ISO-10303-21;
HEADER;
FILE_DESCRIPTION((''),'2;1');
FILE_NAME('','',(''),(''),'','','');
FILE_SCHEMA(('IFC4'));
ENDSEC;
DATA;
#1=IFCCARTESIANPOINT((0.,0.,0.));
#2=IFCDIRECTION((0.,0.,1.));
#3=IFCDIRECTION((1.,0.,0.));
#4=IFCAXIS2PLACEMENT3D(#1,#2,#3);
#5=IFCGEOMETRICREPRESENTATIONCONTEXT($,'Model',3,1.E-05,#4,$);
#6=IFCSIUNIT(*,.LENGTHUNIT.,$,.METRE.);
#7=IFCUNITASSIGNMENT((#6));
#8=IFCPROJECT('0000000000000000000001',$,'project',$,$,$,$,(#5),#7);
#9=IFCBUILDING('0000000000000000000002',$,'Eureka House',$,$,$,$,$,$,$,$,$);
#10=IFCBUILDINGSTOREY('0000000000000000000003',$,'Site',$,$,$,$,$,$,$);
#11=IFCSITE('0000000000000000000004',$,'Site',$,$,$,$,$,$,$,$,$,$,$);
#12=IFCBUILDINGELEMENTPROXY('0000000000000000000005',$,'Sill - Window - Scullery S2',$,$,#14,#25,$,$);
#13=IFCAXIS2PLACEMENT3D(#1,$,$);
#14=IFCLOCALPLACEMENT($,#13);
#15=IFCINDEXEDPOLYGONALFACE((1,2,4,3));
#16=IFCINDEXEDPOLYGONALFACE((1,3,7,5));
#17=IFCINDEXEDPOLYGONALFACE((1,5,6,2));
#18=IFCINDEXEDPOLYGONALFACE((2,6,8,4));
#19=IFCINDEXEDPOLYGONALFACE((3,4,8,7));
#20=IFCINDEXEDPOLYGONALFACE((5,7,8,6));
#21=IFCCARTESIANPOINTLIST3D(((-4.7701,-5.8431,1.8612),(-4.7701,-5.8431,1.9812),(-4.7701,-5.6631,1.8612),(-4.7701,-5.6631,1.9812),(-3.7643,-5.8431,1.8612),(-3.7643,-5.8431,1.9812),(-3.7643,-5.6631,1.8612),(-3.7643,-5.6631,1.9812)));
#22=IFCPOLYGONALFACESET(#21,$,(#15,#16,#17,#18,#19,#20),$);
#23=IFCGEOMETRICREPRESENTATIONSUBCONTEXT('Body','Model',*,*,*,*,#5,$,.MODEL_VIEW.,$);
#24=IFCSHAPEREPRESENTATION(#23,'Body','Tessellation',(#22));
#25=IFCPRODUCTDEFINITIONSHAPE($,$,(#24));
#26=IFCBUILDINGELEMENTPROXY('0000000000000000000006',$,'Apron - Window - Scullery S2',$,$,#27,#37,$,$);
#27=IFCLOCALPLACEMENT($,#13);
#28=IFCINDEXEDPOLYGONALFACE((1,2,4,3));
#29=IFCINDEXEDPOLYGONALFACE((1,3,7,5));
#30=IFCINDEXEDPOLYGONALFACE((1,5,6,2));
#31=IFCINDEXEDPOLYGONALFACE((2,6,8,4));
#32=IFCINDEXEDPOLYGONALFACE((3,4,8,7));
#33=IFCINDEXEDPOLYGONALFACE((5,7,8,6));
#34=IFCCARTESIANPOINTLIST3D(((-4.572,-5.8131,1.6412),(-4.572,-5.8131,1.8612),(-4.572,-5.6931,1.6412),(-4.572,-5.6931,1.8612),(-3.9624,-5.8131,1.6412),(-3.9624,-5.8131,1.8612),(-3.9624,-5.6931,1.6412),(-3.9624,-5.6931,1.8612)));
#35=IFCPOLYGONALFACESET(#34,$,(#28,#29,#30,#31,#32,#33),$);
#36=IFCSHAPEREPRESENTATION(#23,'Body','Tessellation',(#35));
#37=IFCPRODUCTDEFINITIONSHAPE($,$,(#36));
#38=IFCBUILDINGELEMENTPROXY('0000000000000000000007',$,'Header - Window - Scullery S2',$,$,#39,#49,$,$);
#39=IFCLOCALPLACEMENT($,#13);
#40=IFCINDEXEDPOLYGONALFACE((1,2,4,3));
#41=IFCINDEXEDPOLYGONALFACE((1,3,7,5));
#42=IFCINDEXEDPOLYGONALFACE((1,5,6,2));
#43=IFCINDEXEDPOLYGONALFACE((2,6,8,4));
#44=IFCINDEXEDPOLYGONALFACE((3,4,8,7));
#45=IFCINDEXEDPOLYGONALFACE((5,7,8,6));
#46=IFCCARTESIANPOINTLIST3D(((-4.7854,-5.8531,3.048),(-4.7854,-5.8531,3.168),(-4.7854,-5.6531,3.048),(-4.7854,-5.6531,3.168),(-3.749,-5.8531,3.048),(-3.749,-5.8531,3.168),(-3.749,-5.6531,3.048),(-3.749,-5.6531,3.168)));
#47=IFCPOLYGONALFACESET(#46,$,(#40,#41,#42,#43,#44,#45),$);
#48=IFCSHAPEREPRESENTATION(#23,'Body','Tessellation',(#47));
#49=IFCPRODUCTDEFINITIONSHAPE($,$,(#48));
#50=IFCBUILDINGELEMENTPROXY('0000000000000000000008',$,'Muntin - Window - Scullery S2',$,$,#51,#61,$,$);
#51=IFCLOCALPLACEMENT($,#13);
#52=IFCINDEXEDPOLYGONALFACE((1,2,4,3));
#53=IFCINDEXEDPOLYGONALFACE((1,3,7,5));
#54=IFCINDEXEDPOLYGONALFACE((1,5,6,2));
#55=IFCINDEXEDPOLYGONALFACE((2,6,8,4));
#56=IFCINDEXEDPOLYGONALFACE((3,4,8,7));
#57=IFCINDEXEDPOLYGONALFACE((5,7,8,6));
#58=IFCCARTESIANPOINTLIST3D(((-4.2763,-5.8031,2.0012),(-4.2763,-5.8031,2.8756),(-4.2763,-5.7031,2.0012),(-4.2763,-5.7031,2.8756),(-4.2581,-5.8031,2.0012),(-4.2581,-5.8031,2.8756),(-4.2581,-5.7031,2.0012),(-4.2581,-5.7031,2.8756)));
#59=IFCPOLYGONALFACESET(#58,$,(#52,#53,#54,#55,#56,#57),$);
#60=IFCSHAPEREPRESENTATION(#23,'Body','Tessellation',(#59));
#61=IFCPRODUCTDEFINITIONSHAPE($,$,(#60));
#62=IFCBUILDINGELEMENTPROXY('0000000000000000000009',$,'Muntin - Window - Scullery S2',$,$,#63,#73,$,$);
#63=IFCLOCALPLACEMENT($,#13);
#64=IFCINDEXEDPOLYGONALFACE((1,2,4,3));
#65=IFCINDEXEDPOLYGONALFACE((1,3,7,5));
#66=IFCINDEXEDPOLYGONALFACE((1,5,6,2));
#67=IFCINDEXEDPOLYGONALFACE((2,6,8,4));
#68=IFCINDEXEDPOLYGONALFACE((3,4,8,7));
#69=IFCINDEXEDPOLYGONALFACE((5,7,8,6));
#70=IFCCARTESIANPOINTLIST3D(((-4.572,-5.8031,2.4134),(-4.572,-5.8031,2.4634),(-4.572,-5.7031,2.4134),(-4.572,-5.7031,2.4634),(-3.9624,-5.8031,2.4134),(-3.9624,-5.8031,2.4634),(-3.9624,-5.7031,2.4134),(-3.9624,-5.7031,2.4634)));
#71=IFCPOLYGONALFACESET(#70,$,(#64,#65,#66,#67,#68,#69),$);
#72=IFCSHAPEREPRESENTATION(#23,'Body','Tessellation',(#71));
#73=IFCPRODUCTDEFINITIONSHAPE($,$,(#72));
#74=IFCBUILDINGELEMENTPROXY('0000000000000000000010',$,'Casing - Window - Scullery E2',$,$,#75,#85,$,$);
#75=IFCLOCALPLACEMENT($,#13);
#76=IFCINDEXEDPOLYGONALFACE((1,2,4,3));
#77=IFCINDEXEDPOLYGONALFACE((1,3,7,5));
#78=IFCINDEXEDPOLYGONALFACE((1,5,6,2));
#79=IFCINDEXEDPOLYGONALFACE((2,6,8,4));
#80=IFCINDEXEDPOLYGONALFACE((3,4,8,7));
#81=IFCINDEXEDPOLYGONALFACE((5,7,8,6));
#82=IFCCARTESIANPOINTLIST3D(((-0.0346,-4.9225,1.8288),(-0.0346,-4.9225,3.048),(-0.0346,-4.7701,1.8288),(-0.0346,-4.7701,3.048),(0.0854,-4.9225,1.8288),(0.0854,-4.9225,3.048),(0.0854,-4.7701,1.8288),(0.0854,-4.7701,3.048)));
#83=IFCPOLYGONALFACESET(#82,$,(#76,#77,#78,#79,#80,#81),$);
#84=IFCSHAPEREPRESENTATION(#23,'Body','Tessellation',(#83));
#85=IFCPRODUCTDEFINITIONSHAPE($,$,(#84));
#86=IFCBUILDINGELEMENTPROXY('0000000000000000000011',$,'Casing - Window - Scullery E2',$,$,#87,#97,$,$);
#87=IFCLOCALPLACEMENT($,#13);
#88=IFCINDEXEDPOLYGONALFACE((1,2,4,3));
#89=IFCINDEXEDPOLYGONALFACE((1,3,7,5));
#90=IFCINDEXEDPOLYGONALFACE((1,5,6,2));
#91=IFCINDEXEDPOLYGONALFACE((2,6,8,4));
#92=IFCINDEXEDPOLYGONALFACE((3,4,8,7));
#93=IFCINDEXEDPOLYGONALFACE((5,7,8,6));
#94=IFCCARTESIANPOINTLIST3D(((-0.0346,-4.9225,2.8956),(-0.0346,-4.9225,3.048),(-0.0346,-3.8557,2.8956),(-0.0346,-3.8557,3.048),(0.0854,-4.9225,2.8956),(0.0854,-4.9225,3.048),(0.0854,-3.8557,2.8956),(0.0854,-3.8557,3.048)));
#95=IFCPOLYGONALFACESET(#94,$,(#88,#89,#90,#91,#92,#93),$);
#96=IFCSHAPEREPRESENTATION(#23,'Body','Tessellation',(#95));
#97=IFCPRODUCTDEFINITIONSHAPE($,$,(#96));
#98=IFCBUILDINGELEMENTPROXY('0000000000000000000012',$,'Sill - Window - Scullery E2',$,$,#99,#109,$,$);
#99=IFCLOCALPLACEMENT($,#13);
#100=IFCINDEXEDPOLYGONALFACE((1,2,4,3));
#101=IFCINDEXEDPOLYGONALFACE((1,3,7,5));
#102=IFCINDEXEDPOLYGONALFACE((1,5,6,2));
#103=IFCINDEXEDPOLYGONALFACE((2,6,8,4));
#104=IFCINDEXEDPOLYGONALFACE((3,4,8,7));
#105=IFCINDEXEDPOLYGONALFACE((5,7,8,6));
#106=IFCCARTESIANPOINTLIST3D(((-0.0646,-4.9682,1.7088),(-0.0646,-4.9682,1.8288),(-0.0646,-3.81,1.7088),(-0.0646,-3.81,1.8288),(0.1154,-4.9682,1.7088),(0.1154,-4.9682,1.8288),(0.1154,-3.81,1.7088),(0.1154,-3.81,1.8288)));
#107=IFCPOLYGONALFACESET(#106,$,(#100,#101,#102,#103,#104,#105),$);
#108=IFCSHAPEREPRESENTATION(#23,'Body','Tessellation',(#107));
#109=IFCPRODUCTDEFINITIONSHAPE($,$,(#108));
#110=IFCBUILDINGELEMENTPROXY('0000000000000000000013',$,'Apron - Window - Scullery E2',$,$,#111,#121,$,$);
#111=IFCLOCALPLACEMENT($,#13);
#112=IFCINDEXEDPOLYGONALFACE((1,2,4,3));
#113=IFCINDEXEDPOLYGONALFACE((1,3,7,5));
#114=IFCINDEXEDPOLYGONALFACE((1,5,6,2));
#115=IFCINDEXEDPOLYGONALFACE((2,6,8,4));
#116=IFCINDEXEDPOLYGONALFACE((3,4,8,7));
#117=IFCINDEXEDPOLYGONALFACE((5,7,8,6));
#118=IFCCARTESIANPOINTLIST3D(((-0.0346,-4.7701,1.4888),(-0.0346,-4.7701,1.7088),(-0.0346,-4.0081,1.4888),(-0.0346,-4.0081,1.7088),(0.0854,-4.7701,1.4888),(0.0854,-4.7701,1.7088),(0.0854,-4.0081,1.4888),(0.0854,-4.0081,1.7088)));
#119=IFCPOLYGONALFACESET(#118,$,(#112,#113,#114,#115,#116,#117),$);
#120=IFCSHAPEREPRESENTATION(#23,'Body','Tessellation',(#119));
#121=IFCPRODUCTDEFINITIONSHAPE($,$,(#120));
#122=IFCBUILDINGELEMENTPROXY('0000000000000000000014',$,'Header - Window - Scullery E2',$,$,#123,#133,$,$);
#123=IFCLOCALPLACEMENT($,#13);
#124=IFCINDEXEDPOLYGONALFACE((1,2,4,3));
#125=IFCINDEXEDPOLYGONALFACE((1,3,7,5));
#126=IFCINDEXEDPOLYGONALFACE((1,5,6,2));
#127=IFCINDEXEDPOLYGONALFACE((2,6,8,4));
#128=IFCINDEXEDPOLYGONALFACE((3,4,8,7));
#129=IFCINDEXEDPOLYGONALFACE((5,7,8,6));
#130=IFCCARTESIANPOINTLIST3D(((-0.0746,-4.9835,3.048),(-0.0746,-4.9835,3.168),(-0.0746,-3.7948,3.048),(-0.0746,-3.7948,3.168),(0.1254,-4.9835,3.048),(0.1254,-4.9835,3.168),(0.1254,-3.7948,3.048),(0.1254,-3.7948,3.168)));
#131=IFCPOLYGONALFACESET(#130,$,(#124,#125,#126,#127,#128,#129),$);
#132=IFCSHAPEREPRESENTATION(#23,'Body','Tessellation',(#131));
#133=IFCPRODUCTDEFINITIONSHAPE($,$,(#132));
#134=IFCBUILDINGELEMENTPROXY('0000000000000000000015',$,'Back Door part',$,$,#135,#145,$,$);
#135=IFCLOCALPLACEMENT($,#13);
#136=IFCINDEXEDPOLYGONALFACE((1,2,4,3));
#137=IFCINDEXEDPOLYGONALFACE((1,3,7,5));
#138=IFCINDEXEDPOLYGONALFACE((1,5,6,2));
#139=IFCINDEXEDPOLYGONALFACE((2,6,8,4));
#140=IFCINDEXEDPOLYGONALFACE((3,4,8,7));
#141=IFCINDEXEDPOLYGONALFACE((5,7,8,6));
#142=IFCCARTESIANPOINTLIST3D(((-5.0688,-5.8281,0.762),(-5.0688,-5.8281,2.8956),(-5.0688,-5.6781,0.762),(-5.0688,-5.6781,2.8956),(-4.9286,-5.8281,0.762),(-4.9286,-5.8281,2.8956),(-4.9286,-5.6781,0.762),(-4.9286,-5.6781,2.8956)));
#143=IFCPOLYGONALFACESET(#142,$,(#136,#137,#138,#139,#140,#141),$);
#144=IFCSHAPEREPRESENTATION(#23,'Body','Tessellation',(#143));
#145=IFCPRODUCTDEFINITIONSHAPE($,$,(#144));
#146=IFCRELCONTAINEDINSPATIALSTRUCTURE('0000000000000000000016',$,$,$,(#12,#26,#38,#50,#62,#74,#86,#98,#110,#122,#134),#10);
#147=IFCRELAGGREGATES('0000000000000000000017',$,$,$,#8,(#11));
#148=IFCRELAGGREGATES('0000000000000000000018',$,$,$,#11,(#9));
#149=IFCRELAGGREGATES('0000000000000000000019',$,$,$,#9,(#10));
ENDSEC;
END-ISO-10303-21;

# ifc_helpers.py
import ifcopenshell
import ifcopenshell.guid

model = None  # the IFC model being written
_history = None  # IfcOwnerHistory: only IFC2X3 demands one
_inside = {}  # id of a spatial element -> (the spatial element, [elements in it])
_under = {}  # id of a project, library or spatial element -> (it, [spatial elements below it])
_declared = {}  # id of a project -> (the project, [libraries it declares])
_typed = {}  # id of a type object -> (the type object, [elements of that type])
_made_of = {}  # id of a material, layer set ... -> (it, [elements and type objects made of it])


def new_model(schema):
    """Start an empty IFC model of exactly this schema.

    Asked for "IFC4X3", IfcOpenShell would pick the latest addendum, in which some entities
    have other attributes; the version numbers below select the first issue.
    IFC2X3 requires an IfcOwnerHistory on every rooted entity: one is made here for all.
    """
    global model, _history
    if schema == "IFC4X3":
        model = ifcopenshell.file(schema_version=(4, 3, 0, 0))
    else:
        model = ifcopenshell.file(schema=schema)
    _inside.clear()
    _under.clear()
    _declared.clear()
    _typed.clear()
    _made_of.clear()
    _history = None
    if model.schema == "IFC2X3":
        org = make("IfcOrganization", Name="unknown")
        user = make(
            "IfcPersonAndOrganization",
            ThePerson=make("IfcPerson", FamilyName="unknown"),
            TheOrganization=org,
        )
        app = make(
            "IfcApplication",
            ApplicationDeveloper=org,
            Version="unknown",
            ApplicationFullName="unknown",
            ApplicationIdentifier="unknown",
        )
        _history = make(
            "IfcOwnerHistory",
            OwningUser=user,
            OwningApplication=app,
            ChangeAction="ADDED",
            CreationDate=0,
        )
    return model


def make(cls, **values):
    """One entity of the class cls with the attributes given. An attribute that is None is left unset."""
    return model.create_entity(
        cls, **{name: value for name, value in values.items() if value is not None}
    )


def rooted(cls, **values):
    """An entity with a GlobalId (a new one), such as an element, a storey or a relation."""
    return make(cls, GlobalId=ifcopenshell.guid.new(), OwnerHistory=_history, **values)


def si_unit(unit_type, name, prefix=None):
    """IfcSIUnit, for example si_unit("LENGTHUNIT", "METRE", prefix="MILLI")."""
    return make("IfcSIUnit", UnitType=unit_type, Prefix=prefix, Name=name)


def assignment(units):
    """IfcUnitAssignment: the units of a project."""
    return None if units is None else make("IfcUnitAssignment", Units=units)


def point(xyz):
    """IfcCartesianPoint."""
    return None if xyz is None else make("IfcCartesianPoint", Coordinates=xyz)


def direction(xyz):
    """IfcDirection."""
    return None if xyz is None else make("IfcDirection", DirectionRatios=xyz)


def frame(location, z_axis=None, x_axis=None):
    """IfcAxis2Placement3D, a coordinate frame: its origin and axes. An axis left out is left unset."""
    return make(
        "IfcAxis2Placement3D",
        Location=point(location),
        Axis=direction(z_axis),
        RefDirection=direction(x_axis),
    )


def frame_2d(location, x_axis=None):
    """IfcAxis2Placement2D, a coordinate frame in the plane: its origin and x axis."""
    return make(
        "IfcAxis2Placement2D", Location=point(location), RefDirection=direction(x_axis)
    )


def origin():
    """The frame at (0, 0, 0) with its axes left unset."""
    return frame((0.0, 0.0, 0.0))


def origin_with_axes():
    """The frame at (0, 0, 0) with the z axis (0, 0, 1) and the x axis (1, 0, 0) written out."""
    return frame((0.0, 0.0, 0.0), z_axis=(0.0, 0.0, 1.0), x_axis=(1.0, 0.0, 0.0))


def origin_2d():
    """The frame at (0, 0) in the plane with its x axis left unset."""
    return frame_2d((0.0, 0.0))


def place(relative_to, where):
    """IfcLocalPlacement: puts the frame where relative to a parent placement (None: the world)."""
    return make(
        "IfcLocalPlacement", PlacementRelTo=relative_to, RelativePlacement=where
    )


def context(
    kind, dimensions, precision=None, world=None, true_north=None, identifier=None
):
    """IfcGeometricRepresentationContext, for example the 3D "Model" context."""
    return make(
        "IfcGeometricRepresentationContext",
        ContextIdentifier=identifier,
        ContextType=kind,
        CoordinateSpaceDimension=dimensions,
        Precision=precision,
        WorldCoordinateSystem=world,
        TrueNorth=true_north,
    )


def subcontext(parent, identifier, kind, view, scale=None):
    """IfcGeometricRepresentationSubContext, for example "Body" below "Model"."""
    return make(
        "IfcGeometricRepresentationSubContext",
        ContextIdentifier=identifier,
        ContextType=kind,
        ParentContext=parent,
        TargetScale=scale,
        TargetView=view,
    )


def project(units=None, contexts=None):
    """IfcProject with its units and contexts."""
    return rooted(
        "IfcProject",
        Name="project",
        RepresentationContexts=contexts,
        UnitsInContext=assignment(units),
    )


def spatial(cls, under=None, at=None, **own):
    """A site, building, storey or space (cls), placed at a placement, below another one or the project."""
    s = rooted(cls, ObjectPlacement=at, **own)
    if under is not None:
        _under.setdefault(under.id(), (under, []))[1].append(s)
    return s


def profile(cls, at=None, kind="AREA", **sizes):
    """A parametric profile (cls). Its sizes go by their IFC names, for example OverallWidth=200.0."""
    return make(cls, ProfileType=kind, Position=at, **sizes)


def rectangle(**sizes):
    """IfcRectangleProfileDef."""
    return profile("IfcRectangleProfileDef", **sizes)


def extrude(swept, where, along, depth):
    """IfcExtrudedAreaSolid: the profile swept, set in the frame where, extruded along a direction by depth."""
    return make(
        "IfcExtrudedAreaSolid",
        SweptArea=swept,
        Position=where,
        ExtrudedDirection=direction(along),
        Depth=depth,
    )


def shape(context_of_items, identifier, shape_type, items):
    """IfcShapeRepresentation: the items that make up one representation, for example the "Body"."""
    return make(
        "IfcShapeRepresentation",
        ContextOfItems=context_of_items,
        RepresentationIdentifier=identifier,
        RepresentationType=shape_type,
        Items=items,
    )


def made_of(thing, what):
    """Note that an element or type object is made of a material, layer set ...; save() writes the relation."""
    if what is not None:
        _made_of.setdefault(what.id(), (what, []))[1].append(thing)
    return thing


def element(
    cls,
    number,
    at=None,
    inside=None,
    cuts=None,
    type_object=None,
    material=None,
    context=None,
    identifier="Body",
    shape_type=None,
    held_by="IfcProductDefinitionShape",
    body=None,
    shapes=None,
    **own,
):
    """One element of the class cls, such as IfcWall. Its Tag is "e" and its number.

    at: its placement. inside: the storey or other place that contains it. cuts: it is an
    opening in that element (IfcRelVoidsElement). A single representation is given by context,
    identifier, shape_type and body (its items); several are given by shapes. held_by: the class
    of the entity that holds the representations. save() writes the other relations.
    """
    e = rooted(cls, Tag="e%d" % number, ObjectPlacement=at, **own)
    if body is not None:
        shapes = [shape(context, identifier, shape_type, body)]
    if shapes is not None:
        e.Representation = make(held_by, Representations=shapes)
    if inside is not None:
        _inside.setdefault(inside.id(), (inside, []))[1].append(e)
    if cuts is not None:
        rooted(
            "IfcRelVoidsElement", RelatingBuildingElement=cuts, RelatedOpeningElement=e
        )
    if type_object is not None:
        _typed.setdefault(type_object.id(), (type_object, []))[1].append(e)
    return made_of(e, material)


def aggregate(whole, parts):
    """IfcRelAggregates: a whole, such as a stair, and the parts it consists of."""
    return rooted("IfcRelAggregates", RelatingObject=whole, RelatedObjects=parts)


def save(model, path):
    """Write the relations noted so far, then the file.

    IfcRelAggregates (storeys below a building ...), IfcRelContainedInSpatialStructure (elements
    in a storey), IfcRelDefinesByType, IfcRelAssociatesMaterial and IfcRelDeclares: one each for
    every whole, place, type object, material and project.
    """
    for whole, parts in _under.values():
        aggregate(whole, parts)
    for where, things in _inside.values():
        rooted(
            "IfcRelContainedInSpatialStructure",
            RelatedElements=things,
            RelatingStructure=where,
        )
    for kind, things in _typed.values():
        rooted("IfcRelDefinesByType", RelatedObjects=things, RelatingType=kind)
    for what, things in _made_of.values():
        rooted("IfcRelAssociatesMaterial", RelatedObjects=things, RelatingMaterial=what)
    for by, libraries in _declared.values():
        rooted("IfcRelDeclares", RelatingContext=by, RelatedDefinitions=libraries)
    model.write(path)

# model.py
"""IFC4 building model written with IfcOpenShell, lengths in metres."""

from ifc_helpers import new_model, si_unit, frame, origin, origin_with_axes, origin_2d, place, context, subcontext, project, spatial, rectangle, extrude, element, save


model = new_model("IFC4")

# Units and contexts
model_context = context("Model", 3, precision=1e-05, world=origin_with_axes())
body_context = subcontext(model_context, "Body", "Model", "MODEL_VIEW")
ifc_project = project(units=[si_unit("LENGTHUNIT", "METRE")], contexts=[model_context])

# Site, building, storey
site = spatial("IfcSite", under=ifc_project, Name="Site")
building = spatial("IfcBuilding", under=site, Name="Eureka House")
storey = spatial("IfcBuildingStorey", under=building, Name="Site")

# Building element proxies
proxy_1_placement = place(None, frame((-4.2672, -5.7531, 1.8612), z_axis=(0.0, 0.0, 1.0), x_axis=(1.0, 0.0, 0.0)))
element("IfcBuildingElementProxy", 1, at=proxy_1_placement, inside=storey, Name="Sill - Window - Scullery S2", context=body_context, shape_type="SweptSolid", body=[
    extrude(rectangle(XDim=1.0058, YDim=0.18, at=origin_2d()), origin(), (0.0, 0.0, 1.0), 0.12),
])
proxy_2_placement = place(None, frame((-4.2672, -5.7531, 1.6412), z_axis=(0.0, 0.0, 1.0), x_axis=(1.0, 0.0, 0.0)))
element("IfcBuildingElementProxy", 2, at=proxy_2_placement, inside=storey, Name="Apron - Window - Scullery S2", context=body_context, shape_type="SweptSolid", body=[
    extrude(rectangle(XDim=0.6096, YDim=0.12, at=origin_2d()), origin(), (0.0, 0.0, 1.0), 0.22),
])
proxy_3_placement = place(None, frame((-4.2672, -5.7531, 3.048), z_axis=(0.0, 0.0, 1.0), x_axis=(1.0, 0.0, 0.0)))
element("IfcBuildingElementProxy", 3, at=proxy_3_placement, inside=storey, Name="Header - Window - Scullery S2", context=body_context, shape_type="SweptSolid", body=[
    extrude(rectangle(XDim=1.0363, YDim=0.2, at=origin_2d()), origin(), (0.0, 0.0, 1.0), 0.12),
])
proxy_4_placement = place(None, frame((-4.2672, -5.7531, 2.0012), z_axis=(0.0, 0.0, 1.0), x_axis=(1.0, 0.0, 0.0)))
element("IfcBuildingElementProxy", 4, at=proxy_4_placement, inside=storey, Name="Muntin - Window - Scullery S2", context=body_context, shape_type="SweptSolid", body=[
    extrude(rectangle(XDim=0.0183, YDim=0.1, at=origin_2d()), origin(), (0.0, 0.0, 1.0), 0.8744),
])
proxy_5_placement = place(None, frame((-4.2672, -5.7531, 2.4134), z_axis=(0.0, 0.0, 1.0), x_axis=(1.0, 0.0, 0.0)))
element("IfcBuildingElementProxy", 5, at=proxy_5_placement, inside=storey, Name="Muntin - Window - Scullery S2", context=body_context, shape_type="SweptSolid", body=[
    extrude(rectangle(XDim=0.6096, YDim=0.1, at=origin_2d()), origin(), (0.0, 0.0, 1.0), 0.05),
])
proxy_6_placement = place(None, frame((0.0254, -4.8463, 1.8288), z_axis=(0.0, 0.0, 1.0), x_axis=(1.0, 0.0, 0.0)))
element("IfcBuildingElementProxy", 6, at=proxy_6_placement, inside=storey, Name="Casing - Window - Scullery E2", context=body_context, shape_type="SweptSolid", body=[
    extrude(rectangle(XDim=0.12, YDim=0.1524, at=origin_2d()), origin(), (0.0, 0.0, 1.0), 1.2192),
])
proxy_7_placement = place(None, frame((0.0254, -4.3891, 2.8956), z_axis=(0.0, 0.0, 1.0), x_axis=(1.0, 0.0, 0.0)))
element("IfcBuildingElementProxy", 7, at=proxy_7_placement, inside=storey, Name="Casing - Window - Scullery E2", context=body_context, shape_type="SweptSolid", body=[
    extrude(rectangle(XDim=0.12, YDim=1.0668, at=origin_2d()), origin(), (0.0, 0.0, 1.0), 0.1524),
])
proxy_8_placement = place(None, frame((0.0254, -4.3891, 1.7088), z_axis=(0.0, 0.0, 1.0), x_axis=(1.0, 0.0, 0.0)))
element("IfcBuildingElementProxy", 8, at=proxy_8_placement, inside=storey, Name="Sill - Window - Scullery E2", context=body_context, shape_type="SweptSolid", body=[
    extrude(rectangle(XDim=0.18, YDim=1.1582, at=origin_2d()), origin(), (0.0, 0.0, 1.0), 0.12),
])
proxy_9_placement = place(None, frame((0.0254, -4.3891, 1.4888), z_axis=(0.0, 0.0, 1.0), x_axis=(1.0, 0.0, 0.0)))
element("IfcBuildingElementProxy", 9, at=proxy_9_placement, inside=storey, Name="Apron - Window - Scullery E2", context=body_context, shape_type="SweptSolid", body=[
    extrude(rectangle(XDim=0.12, YDim=0.762, at=origin_2d()), origin(), (0.0, 0.0, 1.0), 0.22),
])
proxy_10_placement = place(None, frame((0.0254, -4.3891, 3.048), z_axis=(0.0, 0.0, 1.0), x_axis=(1.0, 0.0, 0.0)))
element("IfcBuildingElementProxy", 10, at=proxy_10_placement, inside=storey, Name="Header - Window - Scullery E2", context=body_context, shape_type="SweptSolid", body=[
    extrude(rectangle(XDim=0.2, YDim=1.1887, at=origin_2d()), origin(), (0.0, 0.0, 1.0), 0.12),
])
proxy_11_placement = place(None, frame((-4.9987, -5.7531, 0.762), z_axis=(0.0, 0.0, 1.0), x_axis=(1.0, 0.0, 0.0)))
element("IfcBuildingElementProxy", 11, at=proxy_11_placement, inside=storey, Name="Back Door part", context=body_context, shape_type="SweptSolid", body=[
    extrude(rectangle(XDim=0.1402, YDim=0.15, at=origin_2d()), origin(), (0.0, 0.0, 1.0), 2.1336),
])

save(model, "model.ifc")
